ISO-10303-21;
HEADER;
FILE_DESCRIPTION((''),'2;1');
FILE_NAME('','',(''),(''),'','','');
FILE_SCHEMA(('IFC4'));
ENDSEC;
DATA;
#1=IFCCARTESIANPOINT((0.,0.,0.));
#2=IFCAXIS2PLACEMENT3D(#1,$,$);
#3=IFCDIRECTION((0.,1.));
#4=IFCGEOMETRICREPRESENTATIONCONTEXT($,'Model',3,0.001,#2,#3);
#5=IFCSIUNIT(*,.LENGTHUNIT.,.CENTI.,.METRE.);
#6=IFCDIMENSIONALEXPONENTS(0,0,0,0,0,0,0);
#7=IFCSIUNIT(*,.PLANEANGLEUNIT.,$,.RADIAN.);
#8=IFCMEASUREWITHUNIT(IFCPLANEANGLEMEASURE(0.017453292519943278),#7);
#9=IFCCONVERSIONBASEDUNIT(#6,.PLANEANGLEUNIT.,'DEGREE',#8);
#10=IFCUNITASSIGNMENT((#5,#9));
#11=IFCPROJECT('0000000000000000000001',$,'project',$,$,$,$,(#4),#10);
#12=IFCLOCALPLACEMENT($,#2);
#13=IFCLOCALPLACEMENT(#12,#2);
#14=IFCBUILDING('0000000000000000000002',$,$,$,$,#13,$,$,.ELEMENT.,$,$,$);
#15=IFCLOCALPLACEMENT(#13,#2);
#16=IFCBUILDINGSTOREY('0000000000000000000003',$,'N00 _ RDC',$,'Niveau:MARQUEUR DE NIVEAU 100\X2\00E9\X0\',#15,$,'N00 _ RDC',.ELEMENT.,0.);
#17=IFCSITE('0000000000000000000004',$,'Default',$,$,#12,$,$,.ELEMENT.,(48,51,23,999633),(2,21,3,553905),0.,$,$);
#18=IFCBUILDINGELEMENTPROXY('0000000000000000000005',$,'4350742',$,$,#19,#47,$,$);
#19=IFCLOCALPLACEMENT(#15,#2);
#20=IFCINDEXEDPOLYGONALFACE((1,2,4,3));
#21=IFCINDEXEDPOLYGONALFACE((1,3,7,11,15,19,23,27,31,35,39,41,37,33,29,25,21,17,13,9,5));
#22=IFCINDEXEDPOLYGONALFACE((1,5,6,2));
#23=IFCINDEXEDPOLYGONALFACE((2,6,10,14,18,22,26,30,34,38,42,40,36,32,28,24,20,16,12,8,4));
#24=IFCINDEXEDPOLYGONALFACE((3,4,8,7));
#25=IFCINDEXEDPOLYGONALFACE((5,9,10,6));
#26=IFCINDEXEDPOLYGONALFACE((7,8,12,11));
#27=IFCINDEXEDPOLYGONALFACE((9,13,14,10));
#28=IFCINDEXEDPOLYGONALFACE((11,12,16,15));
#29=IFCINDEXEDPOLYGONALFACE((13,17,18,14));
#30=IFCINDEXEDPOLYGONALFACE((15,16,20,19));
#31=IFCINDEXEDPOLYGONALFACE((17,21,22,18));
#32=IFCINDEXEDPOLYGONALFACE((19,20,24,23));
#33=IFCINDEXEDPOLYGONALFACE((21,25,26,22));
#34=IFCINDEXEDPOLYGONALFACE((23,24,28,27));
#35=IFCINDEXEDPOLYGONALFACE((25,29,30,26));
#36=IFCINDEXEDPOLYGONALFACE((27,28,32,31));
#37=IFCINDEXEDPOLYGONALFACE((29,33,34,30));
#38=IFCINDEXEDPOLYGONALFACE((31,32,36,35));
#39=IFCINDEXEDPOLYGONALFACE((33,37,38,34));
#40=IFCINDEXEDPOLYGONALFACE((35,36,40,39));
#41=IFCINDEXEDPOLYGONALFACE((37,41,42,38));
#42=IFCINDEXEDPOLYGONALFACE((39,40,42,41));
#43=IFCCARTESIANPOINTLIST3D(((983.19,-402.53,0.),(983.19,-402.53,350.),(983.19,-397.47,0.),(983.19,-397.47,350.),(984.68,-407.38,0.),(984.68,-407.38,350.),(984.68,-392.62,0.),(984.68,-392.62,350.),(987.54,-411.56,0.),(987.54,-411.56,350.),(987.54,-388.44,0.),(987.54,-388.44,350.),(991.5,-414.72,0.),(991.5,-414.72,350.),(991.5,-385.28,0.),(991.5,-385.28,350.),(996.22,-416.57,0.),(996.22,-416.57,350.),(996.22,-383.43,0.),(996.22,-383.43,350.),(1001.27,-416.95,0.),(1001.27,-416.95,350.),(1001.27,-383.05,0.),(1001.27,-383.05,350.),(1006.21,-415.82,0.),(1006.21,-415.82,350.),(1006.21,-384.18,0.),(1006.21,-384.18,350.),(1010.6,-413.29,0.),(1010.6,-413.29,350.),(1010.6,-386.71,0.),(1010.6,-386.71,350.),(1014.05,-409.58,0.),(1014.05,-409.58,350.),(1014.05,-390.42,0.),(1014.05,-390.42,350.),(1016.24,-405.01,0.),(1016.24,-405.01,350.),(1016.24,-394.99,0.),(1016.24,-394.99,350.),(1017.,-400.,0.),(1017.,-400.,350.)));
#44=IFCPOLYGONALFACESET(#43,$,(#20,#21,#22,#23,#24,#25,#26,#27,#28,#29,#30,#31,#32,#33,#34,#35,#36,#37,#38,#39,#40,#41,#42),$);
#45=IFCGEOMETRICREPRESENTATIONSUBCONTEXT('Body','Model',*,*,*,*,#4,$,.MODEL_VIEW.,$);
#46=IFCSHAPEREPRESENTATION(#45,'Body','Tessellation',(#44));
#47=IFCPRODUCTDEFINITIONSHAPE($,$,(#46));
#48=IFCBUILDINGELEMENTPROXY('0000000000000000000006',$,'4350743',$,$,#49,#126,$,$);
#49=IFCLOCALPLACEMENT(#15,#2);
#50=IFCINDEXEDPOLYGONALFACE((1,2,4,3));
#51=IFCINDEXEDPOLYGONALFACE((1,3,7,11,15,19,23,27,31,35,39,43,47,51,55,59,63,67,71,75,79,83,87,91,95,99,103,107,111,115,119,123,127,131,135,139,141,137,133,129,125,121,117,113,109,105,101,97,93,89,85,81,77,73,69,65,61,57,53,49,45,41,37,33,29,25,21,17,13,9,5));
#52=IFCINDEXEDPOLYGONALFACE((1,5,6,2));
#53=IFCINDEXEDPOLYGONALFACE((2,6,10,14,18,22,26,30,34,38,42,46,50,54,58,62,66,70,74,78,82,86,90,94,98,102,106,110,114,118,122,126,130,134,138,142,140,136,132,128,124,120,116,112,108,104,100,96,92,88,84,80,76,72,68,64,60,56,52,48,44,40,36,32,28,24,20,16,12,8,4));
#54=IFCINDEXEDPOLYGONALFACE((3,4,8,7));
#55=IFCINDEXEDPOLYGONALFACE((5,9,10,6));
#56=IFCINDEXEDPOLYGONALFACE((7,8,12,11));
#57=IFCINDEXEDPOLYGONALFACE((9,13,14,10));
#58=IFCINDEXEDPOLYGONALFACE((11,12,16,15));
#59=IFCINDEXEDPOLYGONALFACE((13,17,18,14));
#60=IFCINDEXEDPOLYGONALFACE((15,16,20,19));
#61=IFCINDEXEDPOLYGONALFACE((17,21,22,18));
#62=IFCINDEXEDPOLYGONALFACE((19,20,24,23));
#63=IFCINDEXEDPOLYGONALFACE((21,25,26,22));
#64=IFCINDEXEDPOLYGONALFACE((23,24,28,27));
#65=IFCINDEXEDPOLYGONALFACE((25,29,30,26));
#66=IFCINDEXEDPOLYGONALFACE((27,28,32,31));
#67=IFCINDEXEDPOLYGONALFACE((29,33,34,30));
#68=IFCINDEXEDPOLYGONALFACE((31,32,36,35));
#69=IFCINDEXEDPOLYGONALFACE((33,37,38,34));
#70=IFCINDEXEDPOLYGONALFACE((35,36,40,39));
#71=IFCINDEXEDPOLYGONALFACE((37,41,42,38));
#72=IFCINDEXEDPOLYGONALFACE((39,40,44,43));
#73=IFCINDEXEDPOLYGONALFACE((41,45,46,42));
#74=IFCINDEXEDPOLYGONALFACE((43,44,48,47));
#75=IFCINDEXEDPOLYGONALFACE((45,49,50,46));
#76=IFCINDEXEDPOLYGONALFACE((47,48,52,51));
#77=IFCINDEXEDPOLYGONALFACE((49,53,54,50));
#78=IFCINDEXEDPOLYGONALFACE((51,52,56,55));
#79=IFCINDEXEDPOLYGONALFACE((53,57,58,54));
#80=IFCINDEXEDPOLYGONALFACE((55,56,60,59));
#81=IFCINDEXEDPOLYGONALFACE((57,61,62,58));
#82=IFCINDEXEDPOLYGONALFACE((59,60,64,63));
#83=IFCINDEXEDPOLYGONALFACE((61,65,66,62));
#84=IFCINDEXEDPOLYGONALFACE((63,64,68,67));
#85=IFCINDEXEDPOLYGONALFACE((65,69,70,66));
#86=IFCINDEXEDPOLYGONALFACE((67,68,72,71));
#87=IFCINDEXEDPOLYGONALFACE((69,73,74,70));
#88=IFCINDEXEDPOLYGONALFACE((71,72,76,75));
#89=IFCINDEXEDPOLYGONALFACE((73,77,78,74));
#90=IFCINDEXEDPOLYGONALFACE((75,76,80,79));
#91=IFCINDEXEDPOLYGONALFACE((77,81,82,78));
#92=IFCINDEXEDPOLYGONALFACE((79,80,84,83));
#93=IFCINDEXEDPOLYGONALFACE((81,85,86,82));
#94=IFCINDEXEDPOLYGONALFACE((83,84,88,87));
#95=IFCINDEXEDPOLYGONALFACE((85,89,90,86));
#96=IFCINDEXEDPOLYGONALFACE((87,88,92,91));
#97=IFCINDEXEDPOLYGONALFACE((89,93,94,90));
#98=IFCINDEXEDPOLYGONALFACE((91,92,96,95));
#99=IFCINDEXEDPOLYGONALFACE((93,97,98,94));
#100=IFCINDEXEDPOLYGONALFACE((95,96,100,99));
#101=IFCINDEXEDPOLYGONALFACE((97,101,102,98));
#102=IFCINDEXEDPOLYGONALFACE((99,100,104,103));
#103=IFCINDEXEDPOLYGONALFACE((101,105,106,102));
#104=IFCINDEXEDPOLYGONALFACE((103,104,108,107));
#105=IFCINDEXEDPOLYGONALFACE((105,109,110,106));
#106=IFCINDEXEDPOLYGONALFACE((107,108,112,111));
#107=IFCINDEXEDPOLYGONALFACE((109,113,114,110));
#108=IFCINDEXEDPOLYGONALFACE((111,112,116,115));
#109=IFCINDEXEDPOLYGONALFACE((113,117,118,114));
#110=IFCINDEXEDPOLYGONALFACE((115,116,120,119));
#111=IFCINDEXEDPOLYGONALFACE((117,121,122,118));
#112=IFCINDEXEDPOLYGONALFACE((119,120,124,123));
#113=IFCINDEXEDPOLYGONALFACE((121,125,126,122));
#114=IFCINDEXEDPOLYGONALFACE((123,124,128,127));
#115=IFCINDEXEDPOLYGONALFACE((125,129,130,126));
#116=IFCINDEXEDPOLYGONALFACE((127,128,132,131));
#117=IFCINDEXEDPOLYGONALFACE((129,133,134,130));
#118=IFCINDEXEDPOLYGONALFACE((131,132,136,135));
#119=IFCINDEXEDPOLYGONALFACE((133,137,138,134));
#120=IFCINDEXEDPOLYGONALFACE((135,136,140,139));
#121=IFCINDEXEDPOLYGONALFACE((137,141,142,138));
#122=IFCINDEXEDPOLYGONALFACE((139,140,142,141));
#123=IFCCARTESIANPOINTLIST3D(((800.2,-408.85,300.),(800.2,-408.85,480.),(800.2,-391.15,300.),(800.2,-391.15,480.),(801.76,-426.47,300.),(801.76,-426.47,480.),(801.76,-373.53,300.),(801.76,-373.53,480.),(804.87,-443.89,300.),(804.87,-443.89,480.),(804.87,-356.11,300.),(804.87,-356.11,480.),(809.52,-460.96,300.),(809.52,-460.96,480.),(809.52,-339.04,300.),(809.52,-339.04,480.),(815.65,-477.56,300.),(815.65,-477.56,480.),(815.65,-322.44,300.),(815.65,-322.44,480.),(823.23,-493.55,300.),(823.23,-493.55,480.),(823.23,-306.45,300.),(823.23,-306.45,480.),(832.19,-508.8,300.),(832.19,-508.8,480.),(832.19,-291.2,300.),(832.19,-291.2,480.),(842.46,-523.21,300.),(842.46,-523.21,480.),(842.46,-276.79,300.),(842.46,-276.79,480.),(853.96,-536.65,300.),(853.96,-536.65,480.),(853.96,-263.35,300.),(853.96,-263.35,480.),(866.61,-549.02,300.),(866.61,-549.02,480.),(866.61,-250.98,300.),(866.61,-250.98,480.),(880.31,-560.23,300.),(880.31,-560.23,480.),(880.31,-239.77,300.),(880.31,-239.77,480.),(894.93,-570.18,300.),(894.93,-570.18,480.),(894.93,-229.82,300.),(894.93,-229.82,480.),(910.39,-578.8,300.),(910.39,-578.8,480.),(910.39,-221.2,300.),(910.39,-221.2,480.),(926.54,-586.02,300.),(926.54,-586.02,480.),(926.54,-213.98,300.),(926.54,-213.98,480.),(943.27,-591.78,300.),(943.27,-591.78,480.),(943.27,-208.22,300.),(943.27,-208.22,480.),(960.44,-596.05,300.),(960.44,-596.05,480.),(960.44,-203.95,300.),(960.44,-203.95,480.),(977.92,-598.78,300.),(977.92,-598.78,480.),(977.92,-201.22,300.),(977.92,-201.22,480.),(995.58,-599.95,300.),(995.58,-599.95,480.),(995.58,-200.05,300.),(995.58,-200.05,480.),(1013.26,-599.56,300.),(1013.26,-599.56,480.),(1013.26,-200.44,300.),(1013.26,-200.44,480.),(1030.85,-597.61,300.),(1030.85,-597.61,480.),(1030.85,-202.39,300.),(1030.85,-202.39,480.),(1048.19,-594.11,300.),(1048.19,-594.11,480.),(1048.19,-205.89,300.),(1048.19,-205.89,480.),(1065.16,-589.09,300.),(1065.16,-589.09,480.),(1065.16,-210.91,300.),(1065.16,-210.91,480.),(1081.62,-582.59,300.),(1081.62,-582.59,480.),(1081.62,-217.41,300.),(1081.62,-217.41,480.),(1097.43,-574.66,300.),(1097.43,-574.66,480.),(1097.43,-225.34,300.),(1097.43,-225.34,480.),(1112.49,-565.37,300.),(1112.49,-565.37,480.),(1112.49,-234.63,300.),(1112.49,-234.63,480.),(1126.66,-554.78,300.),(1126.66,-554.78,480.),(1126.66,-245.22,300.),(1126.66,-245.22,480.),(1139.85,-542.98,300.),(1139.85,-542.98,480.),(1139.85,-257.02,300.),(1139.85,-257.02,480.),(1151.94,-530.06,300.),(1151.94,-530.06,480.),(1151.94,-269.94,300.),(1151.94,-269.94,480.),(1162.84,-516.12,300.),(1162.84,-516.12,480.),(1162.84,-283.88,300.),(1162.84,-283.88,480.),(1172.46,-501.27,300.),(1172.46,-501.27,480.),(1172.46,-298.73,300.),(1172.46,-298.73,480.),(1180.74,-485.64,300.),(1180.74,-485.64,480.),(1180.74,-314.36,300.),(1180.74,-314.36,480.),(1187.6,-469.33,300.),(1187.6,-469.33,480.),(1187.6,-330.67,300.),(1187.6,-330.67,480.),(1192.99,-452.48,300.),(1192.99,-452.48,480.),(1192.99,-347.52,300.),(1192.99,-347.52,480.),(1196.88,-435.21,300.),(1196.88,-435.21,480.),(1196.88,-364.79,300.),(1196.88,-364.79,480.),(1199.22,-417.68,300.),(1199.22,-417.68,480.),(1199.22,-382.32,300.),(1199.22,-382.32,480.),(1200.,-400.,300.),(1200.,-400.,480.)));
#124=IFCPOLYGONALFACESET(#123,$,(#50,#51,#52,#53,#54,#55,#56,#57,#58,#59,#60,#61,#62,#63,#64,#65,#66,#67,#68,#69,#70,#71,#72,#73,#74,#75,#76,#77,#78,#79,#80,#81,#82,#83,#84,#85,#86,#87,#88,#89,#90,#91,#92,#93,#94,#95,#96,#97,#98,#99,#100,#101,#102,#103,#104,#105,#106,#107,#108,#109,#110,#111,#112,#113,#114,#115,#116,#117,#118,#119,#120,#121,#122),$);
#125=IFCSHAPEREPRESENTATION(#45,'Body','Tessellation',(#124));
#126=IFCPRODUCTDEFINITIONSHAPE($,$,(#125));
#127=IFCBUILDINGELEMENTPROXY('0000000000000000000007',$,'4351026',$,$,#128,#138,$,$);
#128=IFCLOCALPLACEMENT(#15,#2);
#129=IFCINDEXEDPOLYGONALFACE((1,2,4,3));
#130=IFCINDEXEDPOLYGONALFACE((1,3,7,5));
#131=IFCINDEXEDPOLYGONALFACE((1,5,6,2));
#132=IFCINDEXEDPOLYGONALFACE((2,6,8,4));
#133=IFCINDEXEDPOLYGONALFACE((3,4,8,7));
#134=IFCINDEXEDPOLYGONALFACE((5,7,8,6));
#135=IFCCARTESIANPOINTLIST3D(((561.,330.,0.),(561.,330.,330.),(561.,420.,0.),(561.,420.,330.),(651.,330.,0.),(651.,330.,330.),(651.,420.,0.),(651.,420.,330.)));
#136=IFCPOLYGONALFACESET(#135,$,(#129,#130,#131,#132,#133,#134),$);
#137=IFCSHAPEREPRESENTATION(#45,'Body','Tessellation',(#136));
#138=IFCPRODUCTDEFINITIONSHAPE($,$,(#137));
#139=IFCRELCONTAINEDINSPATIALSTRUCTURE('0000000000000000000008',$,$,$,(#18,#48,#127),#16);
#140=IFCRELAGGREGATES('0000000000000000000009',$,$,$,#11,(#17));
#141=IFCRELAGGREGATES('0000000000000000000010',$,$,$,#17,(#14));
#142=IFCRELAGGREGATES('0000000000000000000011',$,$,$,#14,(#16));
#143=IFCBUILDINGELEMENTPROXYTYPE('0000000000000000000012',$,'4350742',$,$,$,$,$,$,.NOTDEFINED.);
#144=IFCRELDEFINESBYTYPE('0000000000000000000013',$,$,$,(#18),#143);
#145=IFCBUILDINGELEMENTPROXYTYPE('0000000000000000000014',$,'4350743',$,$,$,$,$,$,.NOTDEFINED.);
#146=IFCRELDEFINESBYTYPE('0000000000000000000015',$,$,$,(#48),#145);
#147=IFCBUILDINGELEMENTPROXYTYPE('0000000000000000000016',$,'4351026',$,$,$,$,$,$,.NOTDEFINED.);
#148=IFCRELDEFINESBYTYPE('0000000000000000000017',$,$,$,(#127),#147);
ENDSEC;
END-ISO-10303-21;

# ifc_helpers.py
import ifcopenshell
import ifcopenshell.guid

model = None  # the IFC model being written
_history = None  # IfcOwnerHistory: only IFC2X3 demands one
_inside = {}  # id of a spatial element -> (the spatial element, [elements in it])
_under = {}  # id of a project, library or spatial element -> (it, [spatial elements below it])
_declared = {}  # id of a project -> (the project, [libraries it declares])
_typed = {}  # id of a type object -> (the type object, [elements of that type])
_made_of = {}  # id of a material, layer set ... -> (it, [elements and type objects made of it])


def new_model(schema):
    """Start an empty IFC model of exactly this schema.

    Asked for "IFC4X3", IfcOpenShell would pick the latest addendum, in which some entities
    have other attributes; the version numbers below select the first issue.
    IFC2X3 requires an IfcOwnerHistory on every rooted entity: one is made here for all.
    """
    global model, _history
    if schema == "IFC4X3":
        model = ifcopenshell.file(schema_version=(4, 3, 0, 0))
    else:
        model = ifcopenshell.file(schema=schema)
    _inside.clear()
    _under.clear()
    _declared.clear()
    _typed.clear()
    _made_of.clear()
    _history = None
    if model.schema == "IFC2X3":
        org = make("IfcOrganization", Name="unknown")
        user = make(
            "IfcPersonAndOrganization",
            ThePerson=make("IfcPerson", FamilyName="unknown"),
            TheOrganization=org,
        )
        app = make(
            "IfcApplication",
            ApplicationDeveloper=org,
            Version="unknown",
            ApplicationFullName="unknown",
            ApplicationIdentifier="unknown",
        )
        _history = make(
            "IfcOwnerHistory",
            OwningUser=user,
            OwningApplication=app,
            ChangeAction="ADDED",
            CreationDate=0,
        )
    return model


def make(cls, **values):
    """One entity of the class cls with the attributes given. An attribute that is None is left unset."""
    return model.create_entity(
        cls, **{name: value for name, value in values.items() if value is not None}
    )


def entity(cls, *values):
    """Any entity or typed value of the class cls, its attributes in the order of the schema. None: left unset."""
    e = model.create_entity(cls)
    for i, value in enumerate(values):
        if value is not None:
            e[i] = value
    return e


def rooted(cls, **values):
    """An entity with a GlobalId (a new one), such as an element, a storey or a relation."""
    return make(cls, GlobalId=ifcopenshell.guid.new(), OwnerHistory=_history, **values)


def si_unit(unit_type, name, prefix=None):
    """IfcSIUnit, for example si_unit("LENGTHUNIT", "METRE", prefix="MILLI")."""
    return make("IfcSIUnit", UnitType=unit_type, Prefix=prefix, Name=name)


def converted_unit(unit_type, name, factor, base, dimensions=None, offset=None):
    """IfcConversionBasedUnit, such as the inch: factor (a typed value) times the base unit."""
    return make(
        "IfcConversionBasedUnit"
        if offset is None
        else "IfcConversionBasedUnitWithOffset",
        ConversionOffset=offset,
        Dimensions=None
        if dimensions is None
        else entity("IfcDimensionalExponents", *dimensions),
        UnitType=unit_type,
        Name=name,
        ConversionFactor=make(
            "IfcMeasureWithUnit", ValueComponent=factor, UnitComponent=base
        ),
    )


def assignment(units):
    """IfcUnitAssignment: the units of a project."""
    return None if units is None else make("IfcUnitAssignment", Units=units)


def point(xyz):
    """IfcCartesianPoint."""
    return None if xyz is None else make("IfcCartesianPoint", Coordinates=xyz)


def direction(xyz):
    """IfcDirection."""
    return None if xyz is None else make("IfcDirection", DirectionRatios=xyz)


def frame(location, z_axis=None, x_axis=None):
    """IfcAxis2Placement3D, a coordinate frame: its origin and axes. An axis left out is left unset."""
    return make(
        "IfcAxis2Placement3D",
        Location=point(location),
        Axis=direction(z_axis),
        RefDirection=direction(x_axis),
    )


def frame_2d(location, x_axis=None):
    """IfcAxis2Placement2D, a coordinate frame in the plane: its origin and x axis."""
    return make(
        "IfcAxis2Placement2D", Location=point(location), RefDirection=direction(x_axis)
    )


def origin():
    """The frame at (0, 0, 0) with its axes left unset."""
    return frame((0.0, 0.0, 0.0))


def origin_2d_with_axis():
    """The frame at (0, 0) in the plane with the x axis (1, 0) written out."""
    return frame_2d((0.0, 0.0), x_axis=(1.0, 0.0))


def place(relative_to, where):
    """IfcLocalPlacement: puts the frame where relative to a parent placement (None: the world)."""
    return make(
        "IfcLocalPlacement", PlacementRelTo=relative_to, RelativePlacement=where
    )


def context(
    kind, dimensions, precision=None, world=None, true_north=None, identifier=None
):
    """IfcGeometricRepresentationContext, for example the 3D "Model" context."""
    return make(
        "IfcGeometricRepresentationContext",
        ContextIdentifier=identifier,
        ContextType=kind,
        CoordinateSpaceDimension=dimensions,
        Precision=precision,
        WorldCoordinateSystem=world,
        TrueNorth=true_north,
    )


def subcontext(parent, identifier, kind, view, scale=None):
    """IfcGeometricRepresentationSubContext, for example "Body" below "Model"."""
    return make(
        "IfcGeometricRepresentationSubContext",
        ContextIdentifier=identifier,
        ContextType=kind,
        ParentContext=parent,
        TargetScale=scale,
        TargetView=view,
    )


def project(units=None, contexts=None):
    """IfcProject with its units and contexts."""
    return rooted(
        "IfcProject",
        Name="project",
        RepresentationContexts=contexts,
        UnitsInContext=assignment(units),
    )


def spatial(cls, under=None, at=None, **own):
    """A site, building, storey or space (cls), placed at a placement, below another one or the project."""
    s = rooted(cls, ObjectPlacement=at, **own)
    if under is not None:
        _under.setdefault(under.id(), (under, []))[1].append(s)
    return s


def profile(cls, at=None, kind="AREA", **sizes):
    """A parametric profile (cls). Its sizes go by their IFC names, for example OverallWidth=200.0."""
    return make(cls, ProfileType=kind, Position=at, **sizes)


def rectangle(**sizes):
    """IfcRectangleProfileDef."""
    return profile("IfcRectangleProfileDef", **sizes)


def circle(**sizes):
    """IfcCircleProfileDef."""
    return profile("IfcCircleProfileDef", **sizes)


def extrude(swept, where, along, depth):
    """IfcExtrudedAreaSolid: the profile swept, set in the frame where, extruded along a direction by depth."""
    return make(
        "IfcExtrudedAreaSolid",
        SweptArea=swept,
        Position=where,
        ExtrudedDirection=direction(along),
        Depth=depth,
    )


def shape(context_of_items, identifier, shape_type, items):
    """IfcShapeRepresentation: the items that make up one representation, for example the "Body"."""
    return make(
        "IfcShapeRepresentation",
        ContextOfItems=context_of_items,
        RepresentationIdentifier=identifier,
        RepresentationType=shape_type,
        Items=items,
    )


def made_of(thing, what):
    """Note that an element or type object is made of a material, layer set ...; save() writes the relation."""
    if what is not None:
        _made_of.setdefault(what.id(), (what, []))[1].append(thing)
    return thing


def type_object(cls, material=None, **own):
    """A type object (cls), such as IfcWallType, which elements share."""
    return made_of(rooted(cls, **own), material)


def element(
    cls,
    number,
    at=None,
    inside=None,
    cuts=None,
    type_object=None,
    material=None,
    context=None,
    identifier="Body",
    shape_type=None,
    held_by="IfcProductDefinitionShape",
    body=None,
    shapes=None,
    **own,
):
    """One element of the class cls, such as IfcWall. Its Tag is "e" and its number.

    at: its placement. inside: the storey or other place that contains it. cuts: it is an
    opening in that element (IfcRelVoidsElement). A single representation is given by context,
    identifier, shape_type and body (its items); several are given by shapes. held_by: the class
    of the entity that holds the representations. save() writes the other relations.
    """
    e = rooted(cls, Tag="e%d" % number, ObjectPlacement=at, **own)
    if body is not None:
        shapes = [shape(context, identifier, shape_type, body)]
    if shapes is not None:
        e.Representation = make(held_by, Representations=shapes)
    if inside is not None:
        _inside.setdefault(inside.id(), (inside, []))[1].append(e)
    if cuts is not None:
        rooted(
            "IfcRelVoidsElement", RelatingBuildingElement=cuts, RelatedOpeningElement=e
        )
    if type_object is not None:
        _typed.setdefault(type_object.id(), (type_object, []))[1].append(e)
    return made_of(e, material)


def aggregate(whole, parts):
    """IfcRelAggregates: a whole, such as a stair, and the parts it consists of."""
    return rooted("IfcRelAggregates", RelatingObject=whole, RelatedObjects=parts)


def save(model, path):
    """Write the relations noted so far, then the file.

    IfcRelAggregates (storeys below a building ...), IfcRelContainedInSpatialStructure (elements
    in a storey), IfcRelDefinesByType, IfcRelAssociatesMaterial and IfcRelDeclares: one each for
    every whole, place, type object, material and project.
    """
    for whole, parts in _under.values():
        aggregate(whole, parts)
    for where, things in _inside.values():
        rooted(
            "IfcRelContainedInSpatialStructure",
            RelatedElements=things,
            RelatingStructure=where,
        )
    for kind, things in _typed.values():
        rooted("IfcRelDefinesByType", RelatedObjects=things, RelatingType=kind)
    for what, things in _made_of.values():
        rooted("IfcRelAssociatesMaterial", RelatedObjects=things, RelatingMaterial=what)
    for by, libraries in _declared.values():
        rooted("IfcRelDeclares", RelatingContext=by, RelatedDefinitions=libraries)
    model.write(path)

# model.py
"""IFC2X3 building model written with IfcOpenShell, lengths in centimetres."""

from ifc_helpers import new_model, entity, si_unit, converted_unit, direction, frame, frame_2d, origin, origin_2d_with_axis, place, context, subcontext, project, spatial, rectangle, circle, extrude, type_object, element, save


model = new_model("IFC2X3")

# Units and contexts
model_context = context("Model", 3, precision=0.001, world=origin(), true_north=direction((0.0, 1.0)))
body_context = subcontext(model_context, "Body", "Model", "MODEL_VIEW")
ifc_project = project(units=[si_unit("LENGTHUNIT", "METRE", prefix="CENTI"), converted_unit("PLANEANGLEUNIT", "DEGREE", entity("IfcPlaneAngleMeasure", 0.017453292519943278), si_unit("PLANEANGLEUNIT", "RADIAN"), dimensions=[0, 0, 0, 0, 0, 0, 0])], contexts=[model_context])

# Site, building, storey
site_placement = place(None, origin())
site = spatial("IfcSite", under=ifc_project, at=site_placement, Name="Default", CompositionType="ELEMENT", RefLatitude=(48, 51, 23, 999633), RefLongitude=(2, 21, 3, 553905), RefElevation=0.0)
building_placement = place(site_placement, origin())
building = spatial("IfcBuilding", under=site, at=building_placement, CompositionType="ELEMENT")
storey_placement = place(building_placement, origin())
storey = spatial("IfcBuildingStorey", under=building, at=storey_placement, Name="N00 _ RDC", ObjectType="Niveau:MARQUEUR DE NIVEAU 100é", LongName="N00 _ RDC", CompositionType="ELEMENT", Elevation=0.0)

# Building element proxies
building_element_proxy_type_1 = type_object("IfcBuildingElementProxyType", Name="4350742", PredefinedType="NOTDEFINED")
proxy_1_placement = place(storey_placement, origin())
element("IfcBuildingElementProxy", 1, at=proxy_1_placement, inside=storey, type_object=building_element_proxy_type_1, Name="4350742", context=body_context, shape_type="SweptSolid", body=[
    extrude(circle(Radius=17.0, at=origin_2d_with_axis()), frame((1000.0, -400.0, 0.0)), (0.0, 0.0, 1.0), 350.0),
])
building_element_proxy_type_2 = type_object("IfcBuildingElementProxyType", Name="4350743", PredefinedType="NOTDEFINED")
proxy_2_placement = place(storey_placement, origin())
element("IfcBuildingElementProxy", 2, at=proxy_2_placement, inside=storey, type_object=building_element_proxy_type_2, Name="4350743", context=body_context, shape_type="SweptSolid", body=[
    extrude(circle(Radius=200.0, at=origin_2d_with_axis()), frame((1000.0, -400.0, 300.0)), (0.0, 0.0, 1.0), 180.0),
])
building_element_proxy_type_3 = type_object("IfcBuildingElementProxyType", Name="4351026", PredefinedType="NOTDEFINED")
proxy_3_placement = place(storey_placement, origin())
element("IfcBuildingElementProxy", 3, at=proxy_3_placement, inside=storey, type_object=building_element_proxy_type_3, Name="4351026", context=body_context, shape_type="SweptSolid", body=[
    extrude(rectangle(XDim=90.0, YDim=90.0, at=frame_2d((0.0, 0.0), x_axis=(1.0, 0.0))), frame((606.0, 375.0, 0.0)), (0.0, 0.0, 1.0), 330.0),
])

save(model, "model.ifc")
